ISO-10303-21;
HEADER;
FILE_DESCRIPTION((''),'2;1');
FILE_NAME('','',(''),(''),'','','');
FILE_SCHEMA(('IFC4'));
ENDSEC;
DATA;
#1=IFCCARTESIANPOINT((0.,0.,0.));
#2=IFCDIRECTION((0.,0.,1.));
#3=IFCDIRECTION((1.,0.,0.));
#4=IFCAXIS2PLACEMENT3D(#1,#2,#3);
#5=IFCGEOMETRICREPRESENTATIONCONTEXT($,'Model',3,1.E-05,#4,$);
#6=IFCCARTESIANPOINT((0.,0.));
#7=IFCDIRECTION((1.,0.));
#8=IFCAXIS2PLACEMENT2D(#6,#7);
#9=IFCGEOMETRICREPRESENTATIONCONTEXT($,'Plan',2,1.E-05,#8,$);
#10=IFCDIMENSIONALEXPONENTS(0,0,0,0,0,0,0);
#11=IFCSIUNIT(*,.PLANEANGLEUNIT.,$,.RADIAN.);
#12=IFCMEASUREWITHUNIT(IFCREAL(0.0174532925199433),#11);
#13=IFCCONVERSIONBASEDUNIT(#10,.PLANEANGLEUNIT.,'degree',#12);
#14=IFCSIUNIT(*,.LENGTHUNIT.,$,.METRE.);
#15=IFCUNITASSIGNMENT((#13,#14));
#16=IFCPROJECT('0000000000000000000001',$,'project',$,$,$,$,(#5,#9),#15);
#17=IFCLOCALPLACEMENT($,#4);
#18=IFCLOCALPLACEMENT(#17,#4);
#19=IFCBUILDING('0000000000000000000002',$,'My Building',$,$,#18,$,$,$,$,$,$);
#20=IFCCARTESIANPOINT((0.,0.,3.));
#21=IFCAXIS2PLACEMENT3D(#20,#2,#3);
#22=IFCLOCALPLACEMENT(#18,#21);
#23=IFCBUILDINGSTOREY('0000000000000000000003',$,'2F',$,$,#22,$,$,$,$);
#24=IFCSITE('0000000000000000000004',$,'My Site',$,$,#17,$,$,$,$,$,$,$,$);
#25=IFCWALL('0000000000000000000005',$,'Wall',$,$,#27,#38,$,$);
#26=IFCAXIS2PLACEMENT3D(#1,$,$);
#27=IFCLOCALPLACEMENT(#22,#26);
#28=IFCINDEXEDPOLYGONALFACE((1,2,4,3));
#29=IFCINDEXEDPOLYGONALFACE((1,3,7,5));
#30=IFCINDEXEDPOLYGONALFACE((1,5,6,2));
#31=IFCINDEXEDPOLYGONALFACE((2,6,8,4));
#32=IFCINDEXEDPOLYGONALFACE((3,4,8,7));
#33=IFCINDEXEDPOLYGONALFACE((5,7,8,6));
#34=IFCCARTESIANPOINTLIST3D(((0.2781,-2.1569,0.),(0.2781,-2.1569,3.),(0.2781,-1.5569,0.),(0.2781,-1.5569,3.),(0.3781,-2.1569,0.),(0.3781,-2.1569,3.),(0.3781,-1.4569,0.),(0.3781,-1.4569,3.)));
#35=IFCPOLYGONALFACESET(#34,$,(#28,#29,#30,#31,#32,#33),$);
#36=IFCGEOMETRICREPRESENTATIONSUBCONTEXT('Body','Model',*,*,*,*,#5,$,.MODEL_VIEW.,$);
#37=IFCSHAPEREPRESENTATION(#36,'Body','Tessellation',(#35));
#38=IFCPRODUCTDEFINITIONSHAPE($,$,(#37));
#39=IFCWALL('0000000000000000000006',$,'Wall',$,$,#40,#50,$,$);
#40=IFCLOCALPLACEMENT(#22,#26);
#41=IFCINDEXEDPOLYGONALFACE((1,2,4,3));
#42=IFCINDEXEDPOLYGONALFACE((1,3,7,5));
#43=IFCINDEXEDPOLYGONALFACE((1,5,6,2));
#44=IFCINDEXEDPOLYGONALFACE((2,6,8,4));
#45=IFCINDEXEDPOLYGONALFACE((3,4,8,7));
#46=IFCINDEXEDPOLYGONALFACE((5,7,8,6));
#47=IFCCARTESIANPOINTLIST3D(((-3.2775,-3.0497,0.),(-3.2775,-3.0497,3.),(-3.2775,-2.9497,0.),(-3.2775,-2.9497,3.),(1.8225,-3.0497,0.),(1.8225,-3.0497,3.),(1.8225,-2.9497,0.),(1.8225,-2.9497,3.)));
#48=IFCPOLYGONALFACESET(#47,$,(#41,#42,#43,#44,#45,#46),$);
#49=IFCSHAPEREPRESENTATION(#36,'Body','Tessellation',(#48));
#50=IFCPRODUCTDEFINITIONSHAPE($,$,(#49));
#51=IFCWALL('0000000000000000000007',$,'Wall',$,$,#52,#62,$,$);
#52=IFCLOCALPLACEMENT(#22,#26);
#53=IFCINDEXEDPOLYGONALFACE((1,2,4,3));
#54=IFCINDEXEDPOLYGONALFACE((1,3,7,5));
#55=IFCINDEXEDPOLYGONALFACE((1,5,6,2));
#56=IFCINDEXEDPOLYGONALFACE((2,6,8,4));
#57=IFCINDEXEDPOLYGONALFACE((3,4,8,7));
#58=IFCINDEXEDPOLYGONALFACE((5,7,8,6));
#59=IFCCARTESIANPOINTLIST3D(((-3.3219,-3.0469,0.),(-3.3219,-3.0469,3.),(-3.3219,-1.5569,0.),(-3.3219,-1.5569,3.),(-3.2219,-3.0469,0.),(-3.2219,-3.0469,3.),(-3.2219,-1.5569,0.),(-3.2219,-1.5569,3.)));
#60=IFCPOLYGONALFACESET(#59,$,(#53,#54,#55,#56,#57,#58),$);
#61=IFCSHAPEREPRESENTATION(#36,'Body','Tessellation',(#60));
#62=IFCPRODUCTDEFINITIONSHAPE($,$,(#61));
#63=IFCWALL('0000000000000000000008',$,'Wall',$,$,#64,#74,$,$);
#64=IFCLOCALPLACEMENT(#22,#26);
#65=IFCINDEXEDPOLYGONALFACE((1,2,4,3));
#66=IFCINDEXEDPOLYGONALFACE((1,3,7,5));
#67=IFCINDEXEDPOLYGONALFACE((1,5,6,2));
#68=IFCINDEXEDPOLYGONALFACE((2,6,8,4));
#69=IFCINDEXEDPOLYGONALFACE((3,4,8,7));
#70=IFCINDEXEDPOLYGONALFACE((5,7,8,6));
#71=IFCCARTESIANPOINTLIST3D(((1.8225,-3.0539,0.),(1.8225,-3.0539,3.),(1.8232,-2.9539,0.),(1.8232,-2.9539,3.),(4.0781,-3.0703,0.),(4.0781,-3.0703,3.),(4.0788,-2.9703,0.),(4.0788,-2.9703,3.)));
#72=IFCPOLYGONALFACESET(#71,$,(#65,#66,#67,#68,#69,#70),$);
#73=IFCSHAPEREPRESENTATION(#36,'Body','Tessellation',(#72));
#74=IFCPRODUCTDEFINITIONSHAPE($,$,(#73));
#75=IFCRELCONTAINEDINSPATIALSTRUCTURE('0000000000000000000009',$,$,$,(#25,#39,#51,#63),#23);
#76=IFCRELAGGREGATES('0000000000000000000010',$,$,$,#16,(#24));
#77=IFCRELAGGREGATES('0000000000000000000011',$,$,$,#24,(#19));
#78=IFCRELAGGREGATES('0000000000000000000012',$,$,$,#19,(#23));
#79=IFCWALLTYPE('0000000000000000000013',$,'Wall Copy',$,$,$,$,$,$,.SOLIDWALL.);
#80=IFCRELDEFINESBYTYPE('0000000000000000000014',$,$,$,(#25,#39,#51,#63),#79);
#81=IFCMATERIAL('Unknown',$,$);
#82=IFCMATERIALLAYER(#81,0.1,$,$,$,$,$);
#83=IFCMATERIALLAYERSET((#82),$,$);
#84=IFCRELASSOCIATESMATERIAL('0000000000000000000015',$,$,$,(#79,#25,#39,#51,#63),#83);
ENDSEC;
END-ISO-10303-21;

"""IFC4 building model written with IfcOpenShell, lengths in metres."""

from ifc_helpers import new_model, entity, si_unit, converted_unit, frame, origin_with_axes, origin_2d_with_axis, place, context, subcontext, project, spatial, line, indexed_curve, outline, extrude, material, layer, layer_set, layer_usage, type_object, element, save


model = new_model("IFC4")

# Units and contexts
model_context = context("Model", 3, precision=1e-05, world=origin_with_axes())
plan_context = context("Plan", 2, precision=1e-05, world=origin_2d_with_axis())
body_context_1 = subcontext(model_context, "Body", "Model", "MODEL_VIEW")
ifc_project = project(units=[converted_unit("PLANEANGLEUNIT", "degree", entity("IfcReal", 0.0174532925199433), si_unit("PLANEANGLEUNIT", "RADIAN"), dimensions=[0, 0, 0, 0, 0, 0, 0]), si_unit("LENGTHUNIT", "METRE")], contexts=[model_context, plan_context])

# Site, building, storey
site_placement = place(None, origin_with_axes())
site = spatial("IfcSite", under=ifc_project, at=site_placement, Name="My Site")
building_placement = place(site_placement, origin_with_axes())
building = spatial("IfcBuilding", under=site, at=building_placement, Name="My Building")
storey_placement = place(building_placement, frame((0.0, 0.0, 3.0), z_axis=(0.0, 0.0, 1.0), x_axis=(1.0, 0.0, 0.0)))
storey = spatial("IfcBuildingStorey", under=building, at=storey_placement, Name="2F")

# Shared definitions
ifc_material = material(Name="Unknown")

# Shared definitions
ifc_layer_1 = layer(ifc_material, 0.1)
ifc_layer_set_1 = layer_set([ifc_layer_1])
wall_type = type_object("IfcWallType", Name="Wall Copy", PredefinedType="SOLIDWALL", material=ifc_layer_set_1)

# Walls
ifc_layer_usage_1 = layer_usage(ifc_layer_set_1, "AXIS2", "POSITIVE", 0.0)
wall_1_placement = place(storey_placement, frame((0.2781, -1.5569, 0.0), z_axis=(0.0, 0.0, 1.0), x_axis=(0.0, -1.0, 0.0)))
element("IfcWall", 1, at=wall_1_placement, inside=storey, type_object=wall_type, material=ifc_layer_usage_1, Name="Wall", context=body_context_1, shape_type="SweptSolid", body=[
    extrude(outline(indexed_curve([(0.0, 0.0), (-0.1, 0.1), (0.6, 0.1), (0.6, 0.0)], segments=[line(1, 2, 3, 4, 1)])), origin_with_axes(), (0.0, 0.0, 1.0), 3.0),
])
ifc_layer_usage_2 = layer_usage(ifc_layer_set_1, "AXIS2", "POSITIVE", 0.0)
wall_2_placement = place(storey_placement, frame((1.8225, -2.9497, 0.0), z_axis=(0.0, 0.0, 1.0), x_axis=(-1.0, 0.0, 0.0)))
element("IfcWall", 2, at=wall_2_placement, inside=storey, type_object=wall_type, material=ifc_layer_usage_2, Name="Wall", context=body_context_1, shape_type="SweptSolid", body=[
    extrude(outline(indexed_curve([(0.0, 0.0), (0.0, 0.1), (5.1, 0.1), (5.1, 0.0)], segments=[line(1, 2, 3, 4, 1)])), origin_with_axes(), (0.0, 0.0, 1.0), 3.0),
])
ifc_layer_usage_3 = layer_usage(ifc_layer_set_1, "AXIS2", "POSITIVE", 0.0)
wall_3_placement = place(storey_placement, frame((-3.3219, -1.5569, 0.0), z_axis=(0.0, 0.0, 1.0), x_axis=(0.0, -1.0, 0.0)))
element("IfcWall", 3, at=wall_3_placement, inside=storey, type_object=wall_type, material=ifc_layer_usage_3, Name="Wall", context=body_context_1, shape_type="SweptSolid", body=[
    extrude(outline(indexed_curve([(0.0, 0.0), (0.0, 0.1), (1.49, 0.1), (1.49, 0.0)], segments=[line(1, 2, 3, 4, 1)])), origin_with_axes(), (0.0, 0.0, 1.0), 3.0),
])
ifc_layer_usage_4 = layer_usage(ifc_layer_set_1, "AXIS2", "POSITIVE", 0.0)
wall_4_placement = place(storey_placement, frame((1.8225, -3.0539, 0.0), z_axis=(0.0, 0.0, 1.0), x_axis=(0.999974, -0.007265, 0.0)))
element("IfcWall", 4, at=wall_4_placement, inside=storey, type_object=wall_type, material=ifc_layer_usage_4, Name="Wall", context=body_context_1, shape_type="SweptSolid", body=[
    extrude(outline(indexed_curve([(0.0, 0.0), (0.0, 0.1), (2.2557, 0.1), (2.2557, 0.0)], segments=[line(1, 2, 3, 4, 1)])), origin_with_axes(), (0.0, 0.0, 1.0), 3.0),
])

save(model, "model.ifc")
